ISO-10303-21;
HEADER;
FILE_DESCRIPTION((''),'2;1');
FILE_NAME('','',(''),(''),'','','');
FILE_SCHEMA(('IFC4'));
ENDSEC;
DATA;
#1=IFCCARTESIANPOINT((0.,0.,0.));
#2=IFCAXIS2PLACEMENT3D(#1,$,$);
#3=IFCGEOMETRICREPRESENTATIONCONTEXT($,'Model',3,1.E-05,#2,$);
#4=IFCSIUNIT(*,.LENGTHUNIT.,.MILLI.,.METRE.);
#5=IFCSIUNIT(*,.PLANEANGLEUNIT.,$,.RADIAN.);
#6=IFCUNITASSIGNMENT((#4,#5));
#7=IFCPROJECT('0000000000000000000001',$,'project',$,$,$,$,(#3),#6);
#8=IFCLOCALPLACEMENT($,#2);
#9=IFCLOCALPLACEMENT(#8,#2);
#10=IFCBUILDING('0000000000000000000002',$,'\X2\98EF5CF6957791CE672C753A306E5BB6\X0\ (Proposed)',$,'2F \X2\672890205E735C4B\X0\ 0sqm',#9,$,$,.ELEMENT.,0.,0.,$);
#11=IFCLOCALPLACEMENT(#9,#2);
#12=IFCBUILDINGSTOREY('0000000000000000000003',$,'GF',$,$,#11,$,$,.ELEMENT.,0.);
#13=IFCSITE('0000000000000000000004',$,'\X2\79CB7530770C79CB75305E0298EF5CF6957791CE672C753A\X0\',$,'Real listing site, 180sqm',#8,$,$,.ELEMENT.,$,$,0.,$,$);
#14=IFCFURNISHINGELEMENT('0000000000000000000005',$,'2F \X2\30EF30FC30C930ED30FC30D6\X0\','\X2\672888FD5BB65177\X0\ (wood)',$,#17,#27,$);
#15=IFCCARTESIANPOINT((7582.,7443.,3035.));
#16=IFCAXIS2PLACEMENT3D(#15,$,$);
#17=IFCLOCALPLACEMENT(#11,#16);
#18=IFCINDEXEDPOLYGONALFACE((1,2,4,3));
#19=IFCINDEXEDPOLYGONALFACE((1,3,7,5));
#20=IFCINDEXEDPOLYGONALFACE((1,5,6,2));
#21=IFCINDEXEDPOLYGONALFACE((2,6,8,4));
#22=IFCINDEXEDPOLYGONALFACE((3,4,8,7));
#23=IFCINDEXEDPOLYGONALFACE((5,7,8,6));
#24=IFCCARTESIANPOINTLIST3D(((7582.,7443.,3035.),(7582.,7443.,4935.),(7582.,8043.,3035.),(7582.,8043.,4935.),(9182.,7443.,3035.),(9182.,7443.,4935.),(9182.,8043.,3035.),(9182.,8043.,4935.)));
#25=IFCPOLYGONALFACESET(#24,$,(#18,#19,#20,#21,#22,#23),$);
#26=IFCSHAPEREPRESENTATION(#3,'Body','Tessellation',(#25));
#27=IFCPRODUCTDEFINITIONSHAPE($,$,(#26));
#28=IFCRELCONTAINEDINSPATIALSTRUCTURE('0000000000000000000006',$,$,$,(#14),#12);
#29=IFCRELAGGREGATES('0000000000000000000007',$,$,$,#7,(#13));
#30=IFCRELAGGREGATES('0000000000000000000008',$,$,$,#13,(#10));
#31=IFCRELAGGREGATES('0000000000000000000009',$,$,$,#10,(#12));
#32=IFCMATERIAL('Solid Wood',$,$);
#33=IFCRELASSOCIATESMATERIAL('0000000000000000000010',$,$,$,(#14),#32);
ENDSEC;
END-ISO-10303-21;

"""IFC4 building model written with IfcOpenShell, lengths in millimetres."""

from ifc_helpers import new_model, si_unit, frame, frame_2d, origin, place, context, project, spatial, rectangle, extrude, material, element, save


model = new_model("IFC4")

# Units and contexts
model_context = context("Model", 3, precision=1e-05, world=origin())
ifc_project = project(units=[si_unit("LENGTHUNIT", "METRE", prefix="MILLI"), si_unit("PLANEANGLEUNIT", "RADIAN")], contexts=[model_context])

# Site, building, storey
site_placement = place(None, origin())
site = spatial("IfcSite", under=ifc_project, at=site_placement, Name="秋田県秋田市飯島長野本町", ObjectType="Real listing site, 180sqm", CompositionType="ELEMENT", RefElevation=0.0)
building_placement = place(site_placement, origin())
building = spatial("IfcBuilding", under=site, at=building_placement, Name="飯島長野本町の家 (Proposed)", ObjectType="2F 木造平屋 0sqm", CompositionType="ELEMENT", ElevationOfRefHeight=0.0, ElevationOfTerrain=0.0)
storey_placement = place(building_placement, origin())
storey = spatial("IfcBuildingStorey", under=building, at=storey_placement, Name="GF", CompositionType="ELEMENT", Elevation=0.0)

# Shared definitions
ifc_material_1 = material(Name="Solid Wood")

# Furnishing element
furnishing_1_placement = place(storey_placement, frame((7582.0, 7443.0, 3035.0)))
element("IfcFurnishingElement", 1, at=furnishing_1_placement, inside=storey, material=ifc_material_1, Name="2F ワードローブ", Description="木製家具 (wood)", context=model_context, shape_type="SweptSolid", body=[
    extrude(rectangle(XDim=1600.0, YDim=600.0, at=frame_2d((800.0, 300.0))), frame((7582.0, 7443.0, 3035.0)), (0.0, 0.0, 1.0), 1900.0),
])

save(model, "model.ifc")
